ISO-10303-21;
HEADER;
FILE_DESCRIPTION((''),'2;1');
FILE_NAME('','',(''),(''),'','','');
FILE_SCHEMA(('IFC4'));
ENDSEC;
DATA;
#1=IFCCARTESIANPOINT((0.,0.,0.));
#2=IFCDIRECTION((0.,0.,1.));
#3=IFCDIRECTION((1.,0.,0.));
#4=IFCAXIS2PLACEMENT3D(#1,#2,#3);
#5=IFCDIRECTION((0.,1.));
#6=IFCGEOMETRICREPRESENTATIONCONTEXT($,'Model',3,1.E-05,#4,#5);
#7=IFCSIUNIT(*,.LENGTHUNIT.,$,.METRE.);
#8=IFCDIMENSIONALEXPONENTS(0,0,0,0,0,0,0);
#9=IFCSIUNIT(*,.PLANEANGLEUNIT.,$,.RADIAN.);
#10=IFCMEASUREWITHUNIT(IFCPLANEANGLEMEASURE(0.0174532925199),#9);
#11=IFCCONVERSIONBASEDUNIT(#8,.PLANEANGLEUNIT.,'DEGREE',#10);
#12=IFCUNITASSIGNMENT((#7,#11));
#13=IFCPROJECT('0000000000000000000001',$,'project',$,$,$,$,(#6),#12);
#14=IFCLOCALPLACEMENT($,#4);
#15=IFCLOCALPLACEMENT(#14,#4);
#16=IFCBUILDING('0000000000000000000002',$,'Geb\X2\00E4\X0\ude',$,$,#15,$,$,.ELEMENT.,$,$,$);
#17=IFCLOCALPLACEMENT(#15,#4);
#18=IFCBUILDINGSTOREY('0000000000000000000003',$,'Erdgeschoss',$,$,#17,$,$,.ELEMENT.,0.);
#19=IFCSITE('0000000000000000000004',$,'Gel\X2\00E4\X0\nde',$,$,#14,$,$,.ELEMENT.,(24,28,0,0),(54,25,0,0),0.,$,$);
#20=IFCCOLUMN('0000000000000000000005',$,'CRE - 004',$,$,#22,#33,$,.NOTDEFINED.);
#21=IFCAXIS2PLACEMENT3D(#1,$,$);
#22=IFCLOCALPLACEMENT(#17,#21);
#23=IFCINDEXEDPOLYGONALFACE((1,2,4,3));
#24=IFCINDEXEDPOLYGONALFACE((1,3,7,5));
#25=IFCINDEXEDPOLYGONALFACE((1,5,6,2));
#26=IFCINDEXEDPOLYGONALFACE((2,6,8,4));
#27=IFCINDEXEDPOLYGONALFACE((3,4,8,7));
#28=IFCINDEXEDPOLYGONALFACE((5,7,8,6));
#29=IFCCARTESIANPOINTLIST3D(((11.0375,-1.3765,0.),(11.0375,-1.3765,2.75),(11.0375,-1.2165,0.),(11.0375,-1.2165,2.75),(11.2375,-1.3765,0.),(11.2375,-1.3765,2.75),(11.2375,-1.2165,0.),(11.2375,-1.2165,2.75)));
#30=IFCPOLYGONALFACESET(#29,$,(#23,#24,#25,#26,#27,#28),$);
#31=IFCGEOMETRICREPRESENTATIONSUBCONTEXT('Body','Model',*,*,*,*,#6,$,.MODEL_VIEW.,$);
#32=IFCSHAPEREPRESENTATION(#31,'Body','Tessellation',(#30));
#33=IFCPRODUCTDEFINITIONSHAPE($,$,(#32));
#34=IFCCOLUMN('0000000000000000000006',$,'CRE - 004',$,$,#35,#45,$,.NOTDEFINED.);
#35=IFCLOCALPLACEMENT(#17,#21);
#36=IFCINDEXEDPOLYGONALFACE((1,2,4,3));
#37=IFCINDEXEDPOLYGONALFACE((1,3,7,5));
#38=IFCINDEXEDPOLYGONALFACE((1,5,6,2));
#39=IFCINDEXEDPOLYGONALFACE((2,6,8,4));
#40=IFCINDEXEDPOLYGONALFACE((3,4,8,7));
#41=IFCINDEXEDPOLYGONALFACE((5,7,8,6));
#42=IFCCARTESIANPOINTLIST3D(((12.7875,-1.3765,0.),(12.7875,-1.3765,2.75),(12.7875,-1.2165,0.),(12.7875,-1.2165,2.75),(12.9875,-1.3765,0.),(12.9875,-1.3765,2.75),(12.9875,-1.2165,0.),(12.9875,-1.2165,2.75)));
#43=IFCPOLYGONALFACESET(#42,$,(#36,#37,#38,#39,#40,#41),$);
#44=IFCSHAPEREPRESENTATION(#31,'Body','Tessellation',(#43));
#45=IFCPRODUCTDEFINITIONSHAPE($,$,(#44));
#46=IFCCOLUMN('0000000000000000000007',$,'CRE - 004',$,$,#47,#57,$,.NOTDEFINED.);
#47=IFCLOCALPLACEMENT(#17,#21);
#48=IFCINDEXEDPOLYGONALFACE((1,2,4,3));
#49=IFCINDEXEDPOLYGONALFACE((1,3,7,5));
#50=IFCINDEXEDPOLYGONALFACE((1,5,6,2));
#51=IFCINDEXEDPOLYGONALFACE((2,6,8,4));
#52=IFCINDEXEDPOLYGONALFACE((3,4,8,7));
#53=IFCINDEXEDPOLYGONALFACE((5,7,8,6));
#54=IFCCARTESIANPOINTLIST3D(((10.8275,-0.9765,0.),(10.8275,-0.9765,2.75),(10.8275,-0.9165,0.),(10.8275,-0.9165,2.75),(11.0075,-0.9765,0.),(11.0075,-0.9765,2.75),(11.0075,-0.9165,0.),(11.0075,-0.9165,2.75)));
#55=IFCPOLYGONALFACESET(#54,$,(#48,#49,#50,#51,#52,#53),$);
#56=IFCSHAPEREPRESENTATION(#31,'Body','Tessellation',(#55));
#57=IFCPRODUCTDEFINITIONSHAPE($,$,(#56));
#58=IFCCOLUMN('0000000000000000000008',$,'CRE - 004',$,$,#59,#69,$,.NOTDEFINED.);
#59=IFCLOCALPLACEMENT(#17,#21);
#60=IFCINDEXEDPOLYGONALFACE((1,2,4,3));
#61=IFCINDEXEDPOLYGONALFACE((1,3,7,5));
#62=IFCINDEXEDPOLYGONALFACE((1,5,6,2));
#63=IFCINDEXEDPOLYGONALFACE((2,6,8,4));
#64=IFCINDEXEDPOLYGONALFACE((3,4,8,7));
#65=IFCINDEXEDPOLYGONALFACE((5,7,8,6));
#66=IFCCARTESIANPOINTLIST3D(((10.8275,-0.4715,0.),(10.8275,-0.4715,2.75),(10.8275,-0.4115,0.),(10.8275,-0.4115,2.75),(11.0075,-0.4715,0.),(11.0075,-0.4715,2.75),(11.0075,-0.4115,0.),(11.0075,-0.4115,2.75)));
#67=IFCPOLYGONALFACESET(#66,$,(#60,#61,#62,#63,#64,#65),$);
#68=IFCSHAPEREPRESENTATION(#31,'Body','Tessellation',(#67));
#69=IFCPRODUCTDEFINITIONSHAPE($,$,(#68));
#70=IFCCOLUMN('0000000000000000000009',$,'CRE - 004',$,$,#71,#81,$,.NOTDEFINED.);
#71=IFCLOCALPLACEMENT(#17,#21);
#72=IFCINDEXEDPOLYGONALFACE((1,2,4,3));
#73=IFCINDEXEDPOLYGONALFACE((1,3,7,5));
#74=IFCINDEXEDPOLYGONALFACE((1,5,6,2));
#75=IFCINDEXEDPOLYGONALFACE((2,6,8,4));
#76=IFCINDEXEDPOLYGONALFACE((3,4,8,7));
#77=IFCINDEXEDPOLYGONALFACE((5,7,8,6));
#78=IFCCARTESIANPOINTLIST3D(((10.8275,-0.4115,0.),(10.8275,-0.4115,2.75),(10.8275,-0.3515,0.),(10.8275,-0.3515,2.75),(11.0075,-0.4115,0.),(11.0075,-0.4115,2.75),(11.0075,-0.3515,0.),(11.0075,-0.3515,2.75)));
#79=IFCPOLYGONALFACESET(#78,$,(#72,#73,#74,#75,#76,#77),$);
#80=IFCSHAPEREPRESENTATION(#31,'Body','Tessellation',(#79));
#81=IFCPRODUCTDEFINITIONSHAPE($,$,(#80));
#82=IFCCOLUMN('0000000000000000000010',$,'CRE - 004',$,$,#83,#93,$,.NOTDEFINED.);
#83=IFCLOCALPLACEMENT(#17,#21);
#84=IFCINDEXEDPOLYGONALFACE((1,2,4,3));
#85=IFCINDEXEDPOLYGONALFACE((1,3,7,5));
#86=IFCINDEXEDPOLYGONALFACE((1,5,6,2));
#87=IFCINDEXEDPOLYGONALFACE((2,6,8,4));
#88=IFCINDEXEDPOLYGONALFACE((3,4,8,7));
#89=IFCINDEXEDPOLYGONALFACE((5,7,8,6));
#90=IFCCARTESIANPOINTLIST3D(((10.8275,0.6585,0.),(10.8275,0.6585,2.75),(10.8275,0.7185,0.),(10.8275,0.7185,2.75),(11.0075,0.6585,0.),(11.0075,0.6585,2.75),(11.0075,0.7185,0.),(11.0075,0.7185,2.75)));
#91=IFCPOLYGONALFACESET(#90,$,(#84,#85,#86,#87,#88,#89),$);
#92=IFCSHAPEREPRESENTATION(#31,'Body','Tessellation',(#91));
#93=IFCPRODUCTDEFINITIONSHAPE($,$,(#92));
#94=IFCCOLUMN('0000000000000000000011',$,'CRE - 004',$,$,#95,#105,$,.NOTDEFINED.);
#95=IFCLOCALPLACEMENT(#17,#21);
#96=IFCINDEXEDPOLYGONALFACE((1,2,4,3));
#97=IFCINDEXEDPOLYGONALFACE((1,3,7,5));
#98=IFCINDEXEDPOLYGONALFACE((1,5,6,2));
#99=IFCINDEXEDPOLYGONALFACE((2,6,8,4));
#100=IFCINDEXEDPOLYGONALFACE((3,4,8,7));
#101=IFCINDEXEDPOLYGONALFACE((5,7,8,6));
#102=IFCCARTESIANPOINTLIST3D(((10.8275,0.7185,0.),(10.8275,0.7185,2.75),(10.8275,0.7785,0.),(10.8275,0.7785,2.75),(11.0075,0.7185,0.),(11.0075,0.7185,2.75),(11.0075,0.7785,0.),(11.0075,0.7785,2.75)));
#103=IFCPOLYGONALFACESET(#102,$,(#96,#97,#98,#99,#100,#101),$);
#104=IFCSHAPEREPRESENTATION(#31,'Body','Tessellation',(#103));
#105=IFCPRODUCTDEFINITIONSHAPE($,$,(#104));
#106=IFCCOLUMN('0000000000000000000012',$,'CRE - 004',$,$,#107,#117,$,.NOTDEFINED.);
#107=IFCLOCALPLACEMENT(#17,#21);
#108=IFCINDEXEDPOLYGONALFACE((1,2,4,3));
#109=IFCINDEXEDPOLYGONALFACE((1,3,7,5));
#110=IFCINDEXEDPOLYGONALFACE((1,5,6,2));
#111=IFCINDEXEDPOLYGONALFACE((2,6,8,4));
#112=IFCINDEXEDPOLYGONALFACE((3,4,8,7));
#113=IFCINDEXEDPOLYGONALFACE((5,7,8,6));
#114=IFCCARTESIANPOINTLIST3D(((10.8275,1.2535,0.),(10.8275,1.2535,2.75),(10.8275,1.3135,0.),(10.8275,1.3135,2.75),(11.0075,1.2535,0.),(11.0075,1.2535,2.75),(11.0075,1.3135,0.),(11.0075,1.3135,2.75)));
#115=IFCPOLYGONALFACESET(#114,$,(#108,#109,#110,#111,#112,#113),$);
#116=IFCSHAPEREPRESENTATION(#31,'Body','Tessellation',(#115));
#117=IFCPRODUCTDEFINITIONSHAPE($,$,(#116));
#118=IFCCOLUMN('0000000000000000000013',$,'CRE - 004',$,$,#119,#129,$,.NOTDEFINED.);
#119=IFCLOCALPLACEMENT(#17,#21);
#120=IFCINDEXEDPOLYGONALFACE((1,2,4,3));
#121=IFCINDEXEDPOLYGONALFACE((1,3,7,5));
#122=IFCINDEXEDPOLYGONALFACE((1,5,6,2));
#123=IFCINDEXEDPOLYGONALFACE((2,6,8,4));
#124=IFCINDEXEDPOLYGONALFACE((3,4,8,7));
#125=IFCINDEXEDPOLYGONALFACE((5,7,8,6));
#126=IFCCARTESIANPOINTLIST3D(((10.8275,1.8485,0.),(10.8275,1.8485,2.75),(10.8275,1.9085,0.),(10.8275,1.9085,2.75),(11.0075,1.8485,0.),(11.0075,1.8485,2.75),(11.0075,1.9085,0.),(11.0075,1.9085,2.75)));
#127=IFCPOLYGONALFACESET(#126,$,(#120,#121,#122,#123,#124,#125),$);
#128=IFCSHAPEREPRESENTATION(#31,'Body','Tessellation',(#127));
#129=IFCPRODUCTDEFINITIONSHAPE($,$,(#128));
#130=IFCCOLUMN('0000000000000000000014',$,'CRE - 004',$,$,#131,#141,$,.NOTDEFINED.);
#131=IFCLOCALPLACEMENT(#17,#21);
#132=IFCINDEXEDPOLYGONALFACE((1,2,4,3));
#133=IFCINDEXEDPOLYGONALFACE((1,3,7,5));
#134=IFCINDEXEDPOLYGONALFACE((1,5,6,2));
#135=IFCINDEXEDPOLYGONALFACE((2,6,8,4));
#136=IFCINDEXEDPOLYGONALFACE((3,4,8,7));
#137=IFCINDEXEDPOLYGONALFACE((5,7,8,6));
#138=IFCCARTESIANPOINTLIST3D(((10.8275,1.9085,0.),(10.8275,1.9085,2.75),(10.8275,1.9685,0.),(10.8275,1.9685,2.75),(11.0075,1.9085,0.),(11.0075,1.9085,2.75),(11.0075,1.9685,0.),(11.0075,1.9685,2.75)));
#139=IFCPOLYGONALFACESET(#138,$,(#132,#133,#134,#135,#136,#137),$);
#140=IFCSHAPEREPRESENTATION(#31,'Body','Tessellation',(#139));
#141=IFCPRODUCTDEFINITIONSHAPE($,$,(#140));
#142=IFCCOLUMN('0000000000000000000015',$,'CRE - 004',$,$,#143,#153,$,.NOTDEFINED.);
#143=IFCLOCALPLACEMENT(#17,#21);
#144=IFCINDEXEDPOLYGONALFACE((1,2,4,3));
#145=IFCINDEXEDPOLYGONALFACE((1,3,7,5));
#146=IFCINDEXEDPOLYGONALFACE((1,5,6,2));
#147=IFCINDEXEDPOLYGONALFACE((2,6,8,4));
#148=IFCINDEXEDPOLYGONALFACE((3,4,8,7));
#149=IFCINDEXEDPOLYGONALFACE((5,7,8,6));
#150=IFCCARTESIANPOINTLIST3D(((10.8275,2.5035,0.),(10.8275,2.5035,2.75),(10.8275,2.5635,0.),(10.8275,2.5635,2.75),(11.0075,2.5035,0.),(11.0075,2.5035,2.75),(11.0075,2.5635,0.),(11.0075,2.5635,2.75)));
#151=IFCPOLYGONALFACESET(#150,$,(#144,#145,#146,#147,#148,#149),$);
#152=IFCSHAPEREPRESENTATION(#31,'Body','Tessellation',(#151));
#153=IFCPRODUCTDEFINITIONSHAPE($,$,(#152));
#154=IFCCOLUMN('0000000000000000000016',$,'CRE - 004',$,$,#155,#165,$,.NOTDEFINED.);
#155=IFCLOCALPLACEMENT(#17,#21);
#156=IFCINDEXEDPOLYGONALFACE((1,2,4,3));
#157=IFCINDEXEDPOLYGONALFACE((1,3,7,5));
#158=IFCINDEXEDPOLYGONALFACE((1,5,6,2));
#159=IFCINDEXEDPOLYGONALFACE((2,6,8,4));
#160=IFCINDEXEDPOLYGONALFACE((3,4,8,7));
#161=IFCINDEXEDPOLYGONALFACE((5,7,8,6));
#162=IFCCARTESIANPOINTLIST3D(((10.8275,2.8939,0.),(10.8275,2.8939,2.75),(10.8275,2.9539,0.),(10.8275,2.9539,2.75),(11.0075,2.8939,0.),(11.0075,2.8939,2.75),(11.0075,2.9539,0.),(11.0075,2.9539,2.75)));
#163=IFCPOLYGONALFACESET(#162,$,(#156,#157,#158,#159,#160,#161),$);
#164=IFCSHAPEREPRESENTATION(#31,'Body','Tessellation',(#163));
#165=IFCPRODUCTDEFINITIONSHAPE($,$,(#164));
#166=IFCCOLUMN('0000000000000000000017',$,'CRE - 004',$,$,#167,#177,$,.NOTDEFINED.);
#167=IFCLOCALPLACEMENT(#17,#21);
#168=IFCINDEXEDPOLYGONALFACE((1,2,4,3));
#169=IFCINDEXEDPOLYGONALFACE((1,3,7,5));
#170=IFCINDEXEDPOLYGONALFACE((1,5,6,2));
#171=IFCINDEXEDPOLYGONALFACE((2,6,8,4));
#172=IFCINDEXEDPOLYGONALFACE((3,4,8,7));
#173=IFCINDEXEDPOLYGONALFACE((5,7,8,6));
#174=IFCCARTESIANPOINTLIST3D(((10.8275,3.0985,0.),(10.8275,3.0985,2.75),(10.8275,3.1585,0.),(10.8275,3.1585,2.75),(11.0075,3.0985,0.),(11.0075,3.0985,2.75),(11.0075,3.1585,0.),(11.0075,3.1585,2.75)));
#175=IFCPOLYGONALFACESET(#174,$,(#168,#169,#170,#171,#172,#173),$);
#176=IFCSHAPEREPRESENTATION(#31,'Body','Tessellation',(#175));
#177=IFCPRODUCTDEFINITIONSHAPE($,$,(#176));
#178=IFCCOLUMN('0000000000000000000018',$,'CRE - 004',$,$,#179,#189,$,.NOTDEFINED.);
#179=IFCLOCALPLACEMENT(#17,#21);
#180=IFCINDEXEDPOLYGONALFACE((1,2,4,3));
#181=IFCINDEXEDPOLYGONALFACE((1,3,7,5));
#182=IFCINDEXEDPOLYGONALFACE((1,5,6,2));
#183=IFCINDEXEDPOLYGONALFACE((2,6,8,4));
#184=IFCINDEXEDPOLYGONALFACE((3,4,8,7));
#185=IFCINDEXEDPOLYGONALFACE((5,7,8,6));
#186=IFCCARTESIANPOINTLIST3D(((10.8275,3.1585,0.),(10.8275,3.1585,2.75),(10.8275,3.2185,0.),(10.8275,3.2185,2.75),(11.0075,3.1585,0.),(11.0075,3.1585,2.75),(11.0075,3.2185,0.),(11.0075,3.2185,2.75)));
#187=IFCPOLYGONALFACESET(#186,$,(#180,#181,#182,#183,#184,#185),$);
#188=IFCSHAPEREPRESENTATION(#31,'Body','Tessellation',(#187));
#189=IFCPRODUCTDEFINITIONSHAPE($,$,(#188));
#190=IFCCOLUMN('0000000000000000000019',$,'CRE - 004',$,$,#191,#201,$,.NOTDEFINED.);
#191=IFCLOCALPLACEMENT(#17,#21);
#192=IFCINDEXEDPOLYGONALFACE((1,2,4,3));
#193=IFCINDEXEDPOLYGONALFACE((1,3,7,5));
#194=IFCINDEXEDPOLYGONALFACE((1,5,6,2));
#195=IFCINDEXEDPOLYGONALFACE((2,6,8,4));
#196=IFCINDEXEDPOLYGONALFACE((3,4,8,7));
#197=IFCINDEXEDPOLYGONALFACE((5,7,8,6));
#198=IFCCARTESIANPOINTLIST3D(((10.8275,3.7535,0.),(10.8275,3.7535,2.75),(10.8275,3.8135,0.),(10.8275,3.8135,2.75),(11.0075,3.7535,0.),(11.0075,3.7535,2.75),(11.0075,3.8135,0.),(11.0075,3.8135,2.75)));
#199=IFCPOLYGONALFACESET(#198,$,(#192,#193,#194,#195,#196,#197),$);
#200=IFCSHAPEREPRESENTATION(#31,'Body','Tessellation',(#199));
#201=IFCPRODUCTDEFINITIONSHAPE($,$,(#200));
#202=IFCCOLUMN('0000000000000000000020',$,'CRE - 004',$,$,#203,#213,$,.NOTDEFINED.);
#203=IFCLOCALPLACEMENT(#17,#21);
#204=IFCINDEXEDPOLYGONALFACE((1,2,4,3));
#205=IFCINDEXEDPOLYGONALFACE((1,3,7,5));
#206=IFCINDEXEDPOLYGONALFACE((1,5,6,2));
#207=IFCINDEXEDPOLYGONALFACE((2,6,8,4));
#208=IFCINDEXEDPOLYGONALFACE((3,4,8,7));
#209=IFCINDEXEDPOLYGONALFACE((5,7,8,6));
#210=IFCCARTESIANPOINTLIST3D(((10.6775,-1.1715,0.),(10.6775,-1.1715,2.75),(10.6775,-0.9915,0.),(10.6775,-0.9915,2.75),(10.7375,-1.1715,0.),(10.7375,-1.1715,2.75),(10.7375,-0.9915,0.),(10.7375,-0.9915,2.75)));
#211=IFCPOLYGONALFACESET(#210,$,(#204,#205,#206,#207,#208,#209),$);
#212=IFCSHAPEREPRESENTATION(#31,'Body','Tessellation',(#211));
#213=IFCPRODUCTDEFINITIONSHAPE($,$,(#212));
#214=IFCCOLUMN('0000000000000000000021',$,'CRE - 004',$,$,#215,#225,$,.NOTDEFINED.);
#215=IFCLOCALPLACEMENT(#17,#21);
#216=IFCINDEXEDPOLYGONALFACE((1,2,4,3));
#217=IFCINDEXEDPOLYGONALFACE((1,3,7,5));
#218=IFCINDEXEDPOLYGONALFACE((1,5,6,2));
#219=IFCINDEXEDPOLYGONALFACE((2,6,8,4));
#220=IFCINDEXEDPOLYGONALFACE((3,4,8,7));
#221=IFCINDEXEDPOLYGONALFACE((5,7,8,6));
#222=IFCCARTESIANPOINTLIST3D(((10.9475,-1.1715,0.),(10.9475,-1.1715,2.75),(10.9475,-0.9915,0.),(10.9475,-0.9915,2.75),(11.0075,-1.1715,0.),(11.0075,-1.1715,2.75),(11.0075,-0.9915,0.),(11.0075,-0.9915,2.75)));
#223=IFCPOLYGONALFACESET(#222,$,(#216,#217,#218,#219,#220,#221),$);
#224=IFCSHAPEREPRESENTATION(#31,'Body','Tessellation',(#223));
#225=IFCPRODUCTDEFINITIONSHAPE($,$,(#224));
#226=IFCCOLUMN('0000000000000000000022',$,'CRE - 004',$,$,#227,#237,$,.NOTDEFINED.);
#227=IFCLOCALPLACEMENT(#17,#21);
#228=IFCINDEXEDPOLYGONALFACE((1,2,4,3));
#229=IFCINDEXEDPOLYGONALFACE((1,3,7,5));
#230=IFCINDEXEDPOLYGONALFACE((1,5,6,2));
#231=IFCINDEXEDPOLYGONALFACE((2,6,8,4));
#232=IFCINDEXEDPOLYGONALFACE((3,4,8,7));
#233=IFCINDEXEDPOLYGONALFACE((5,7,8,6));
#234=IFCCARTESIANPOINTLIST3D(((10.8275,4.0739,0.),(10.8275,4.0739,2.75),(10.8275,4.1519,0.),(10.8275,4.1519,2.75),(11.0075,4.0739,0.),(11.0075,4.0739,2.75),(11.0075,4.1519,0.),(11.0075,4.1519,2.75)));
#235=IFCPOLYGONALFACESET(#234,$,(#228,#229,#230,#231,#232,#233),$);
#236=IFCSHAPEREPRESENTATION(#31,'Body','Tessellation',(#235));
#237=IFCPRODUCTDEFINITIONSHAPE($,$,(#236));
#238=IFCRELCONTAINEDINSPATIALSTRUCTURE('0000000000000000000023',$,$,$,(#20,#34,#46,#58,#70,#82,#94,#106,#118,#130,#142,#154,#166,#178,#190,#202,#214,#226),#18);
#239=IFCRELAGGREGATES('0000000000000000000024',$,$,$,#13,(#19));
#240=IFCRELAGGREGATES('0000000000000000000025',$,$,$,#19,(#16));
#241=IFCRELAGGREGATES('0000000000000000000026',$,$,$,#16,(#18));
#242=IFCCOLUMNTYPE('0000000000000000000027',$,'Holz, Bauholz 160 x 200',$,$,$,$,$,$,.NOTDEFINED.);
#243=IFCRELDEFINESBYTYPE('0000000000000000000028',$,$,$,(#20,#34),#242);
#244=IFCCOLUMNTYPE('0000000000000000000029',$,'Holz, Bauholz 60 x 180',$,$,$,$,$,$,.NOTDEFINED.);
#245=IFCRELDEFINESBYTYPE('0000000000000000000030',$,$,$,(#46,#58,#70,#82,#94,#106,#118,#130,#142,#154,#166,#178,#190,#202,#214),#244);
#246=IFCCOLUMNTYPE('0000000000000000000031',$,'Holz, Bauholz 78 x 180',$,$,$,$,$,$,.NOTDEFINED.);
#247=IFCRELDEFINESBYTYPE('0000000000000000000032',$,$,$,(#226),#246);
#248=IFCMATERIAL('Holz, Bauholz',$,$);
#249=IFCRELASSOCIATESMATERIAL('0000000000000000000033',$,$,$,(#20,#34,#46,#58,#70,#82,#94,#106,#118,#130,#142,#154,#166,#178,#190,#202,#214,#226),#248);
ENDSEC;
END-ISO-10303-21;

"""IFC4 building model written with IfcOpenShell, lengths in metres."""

from ifc_helpers import new_model, entity, si_unit, converted_unit, direction, frame, origin_with_axes, origin_2d_with_axis, place, context, subcontext, project, spatial, rectangle, extrude, material, type_object, element, save


model = new_model("IFC4")

# Units and contexts
model_context = context("Model", 3, precision=1e-05, world=origin_with_axes(), true_north=direction((0.0, 1.0)))
body_context = subcontext(model_context, "Body", "Model", "MODEL_VIEW")
ifc_project = project(units=[si_unit("LENGTHUNIT", "METRE"), converted_unit("PLANEANGLEUNIT", "DEGREE", entity("IfcPlaneAngleMeasure", 0.0174532925199), si_unit("PLANEANGLEUNIT", "RADIAN"), dimensions=[0, 0, 0, 0, 0, 0, 0])], contexts=[model_context])

# Site, building, storey
site_placement = place(None, origin_with_axes())
site = spatial("IfcSite", under=ifc_project, at=site_placement, Name="Gelände", CompositionType="ELEMENT", RefLatitude=(24, 28, 0, 0), RefLongitude=(54, 25, 0, 0), RefElevation=0.0)
building_placement = place(site_placement, origin_with_axes())
building = spatial("IfcBuilding", under=site, at=building_placement, Name="Gebäude", CompositionType="ELEMENT")
storey_placement = place(building_placement, origin_with_axes())
storey = spatial("IfcBuildingStorey", under=building, at=storey_placement, Name="Erdgeschoss", CompositionType="ELEMENT", Elevation=0.0)

# Columns
ifc_material_1 = material(Name="Holz, Bauholz")
column_type_1 = type_object("IfcColumnType", Name="Holz, Bauholz 160 x 200", PredefinedType="NOTDEFINED")
for number, where, z_axis, x_axis, name in (
    (1, (11.1375, -1.2965, 0.0), (0.0, 0.0, 1.0), (1.0, 0.0, 0.0), "CRE - 004"),
    (2, (12.8875, -1.2965, 0.0), (0.0, 0.0, 1.0), (1.0, 0.0, 0.0), "CRE - 004"),
):
    element("IfcColumn", number, at=place(storey_placement, frame(where, z_axis=z_axis, x_axis=x_axis)), inside=storey, type_object=column_type_1, material=ifc_material_1, Name=name, PredefinedType="NOTDEFINED", context=body_context, shape_type="SweptSolid", body=[
        extrude(rectangle(XDim=0.16, YDim=0.2, at=origin_2d_with_axis()), frame((0.0, 0.0, 0.0), z_axis=(0.0, 0.0, 1.0), x_axis=(0.0, 1.0, 0.0)), (0.0, 0.0, 1.0), 2.75),
    ])
column_type_2 = type_object("IfcColumnType", Name="Holz, Bauholz 60 x 180", PredefinedType="NOTDEFINED")
for number, where, z_axis, x_axis, name in (
    (3, (10.9175, -0.9465, 0.0), (0.0, 0.0, 1.0), (1.0, 0.0, 0.0), "CRE - 004"),
    (4, (10.9175, -0.4415, 0.0), (0.0, 0.0, 1.0), (1.0, 0.0, 0.0), "CRE - 004"),
    (5, (10.9175, -0.3815, 0.0), (0.0, 0.0, 1.0), (1.0, 0.0, 0.0), "CRE - 004"),
    (6, (10.9175, 0.6885, 0.0), (0.0, 0.0, 1.0), (1.0, 0.0, 0.0), "CRE - 004"),
    (7, (10.9175, 0.7485, 0.0), (0.0, 0.0, 1.0), (1.0, 0.0, 0.0), "CRE - 004"),
    (8, (10.9175, 1.2835, 0.0), (0.0, 0.0, 1.0), (1.0, 0.0, 0.0), "CRE - 004"),
    (9, (10.9175, 1.8785, 0.0), (0.0, 0.0, 1.0), (1.0, 0.0, 0.0), "CRE - 004"),
    (10, (10.9175, 1.9385, 0.0), (0.0, 0.0, 1.0), (1.0, 0.0, 0.0), "CRE - 004"),
    (11, (10.9175, 2.5335, 0.0), (0.0, 0.0, 1.0), (1.0, 0.0, 0.0), "CRE - 004"),
    (12, (10.9175, 2.9239, 0.0), (0.0, 0.0, 1.0), (1.0, 0.0, 0.0), "CRE - 004"),
    (13, (10.9175, 3.1285, 0.0), (0.0, 0.0, 1.0), (1.0, 0.0, 0.0), "CRE - 004"),
    (14, (10.9175, 3.1885, 0.0), (0.0, 0.0, 1.0), (1.0, 0.0, 0.0), "CRE - 004"),
    (15, (10.9175, 3.7835, 0.0), (0.0, 0.0, 1.0), (1.0, 0.0, 0.0), "CRE - 004"),
    (16, (10.7075, -1.0815, 0.0), (0.0, 0.0, 1.0), (0.0, -1.0, 0.0), "CRE - 004"),
    (17, (10.9775, -1.0815, 0.0), (0.0, 0.0, 1.0), (0.0, -1.0, 0.0), "CRE - 004"),
):
    element("IfcColumn", number, at=place(storey_placement, frame(where, z_axis=z_axis, x_axis=x_axis)), inside=storey, type_object=column_type_2, material=ifc_material_1, Name=name, PredefinedType="NOTDEFINED", context=body_context, shape_type="SweptSolid", body=[
        extrude(rectangle(XDim=0.06, YDim=0.18, at=origin_2d_with_axis()), frame((0.0, 0.0, 0.0), z_axis=(0.0, 0.0, 1.0), x_axis=(0.0, 1.0, 0.0)), (0.0, 0.0, 1.0), 2.75),
    ])
column_type_3 = type_object("IfcColumnType", Name="Holz, Bauholz 78 x 180", PredefinedType="NOTDEFINED")
column_1_placement = place(storey_placement, frame((10.9175, 4.1129, 0.0), z_axis=(0.0, 0.0, 1.0), x_axis=(1.0, 0.0, 0.0)))
element("IfcColumn", 18, at=column_1_placement, inside=storey, type_object=column_type_3, material=ifc_material_1, Name="CRE - 004", PredefinedType="NOTDEFINED", context=body_context, shape_type="SweptSolid", body=[
    extrude(rectangle(XDim=0.078, YDim=0.18, at=origin_2d_with_axis()), frame((0.0, 0.0, 0.0), z_axis=(0.0, 0.0, 1.0), x_axis=(0.0, 1.0, 0.0)), (0.0, 0.0, 1.0), 2.75),
])

save(model, "model.ifc")
